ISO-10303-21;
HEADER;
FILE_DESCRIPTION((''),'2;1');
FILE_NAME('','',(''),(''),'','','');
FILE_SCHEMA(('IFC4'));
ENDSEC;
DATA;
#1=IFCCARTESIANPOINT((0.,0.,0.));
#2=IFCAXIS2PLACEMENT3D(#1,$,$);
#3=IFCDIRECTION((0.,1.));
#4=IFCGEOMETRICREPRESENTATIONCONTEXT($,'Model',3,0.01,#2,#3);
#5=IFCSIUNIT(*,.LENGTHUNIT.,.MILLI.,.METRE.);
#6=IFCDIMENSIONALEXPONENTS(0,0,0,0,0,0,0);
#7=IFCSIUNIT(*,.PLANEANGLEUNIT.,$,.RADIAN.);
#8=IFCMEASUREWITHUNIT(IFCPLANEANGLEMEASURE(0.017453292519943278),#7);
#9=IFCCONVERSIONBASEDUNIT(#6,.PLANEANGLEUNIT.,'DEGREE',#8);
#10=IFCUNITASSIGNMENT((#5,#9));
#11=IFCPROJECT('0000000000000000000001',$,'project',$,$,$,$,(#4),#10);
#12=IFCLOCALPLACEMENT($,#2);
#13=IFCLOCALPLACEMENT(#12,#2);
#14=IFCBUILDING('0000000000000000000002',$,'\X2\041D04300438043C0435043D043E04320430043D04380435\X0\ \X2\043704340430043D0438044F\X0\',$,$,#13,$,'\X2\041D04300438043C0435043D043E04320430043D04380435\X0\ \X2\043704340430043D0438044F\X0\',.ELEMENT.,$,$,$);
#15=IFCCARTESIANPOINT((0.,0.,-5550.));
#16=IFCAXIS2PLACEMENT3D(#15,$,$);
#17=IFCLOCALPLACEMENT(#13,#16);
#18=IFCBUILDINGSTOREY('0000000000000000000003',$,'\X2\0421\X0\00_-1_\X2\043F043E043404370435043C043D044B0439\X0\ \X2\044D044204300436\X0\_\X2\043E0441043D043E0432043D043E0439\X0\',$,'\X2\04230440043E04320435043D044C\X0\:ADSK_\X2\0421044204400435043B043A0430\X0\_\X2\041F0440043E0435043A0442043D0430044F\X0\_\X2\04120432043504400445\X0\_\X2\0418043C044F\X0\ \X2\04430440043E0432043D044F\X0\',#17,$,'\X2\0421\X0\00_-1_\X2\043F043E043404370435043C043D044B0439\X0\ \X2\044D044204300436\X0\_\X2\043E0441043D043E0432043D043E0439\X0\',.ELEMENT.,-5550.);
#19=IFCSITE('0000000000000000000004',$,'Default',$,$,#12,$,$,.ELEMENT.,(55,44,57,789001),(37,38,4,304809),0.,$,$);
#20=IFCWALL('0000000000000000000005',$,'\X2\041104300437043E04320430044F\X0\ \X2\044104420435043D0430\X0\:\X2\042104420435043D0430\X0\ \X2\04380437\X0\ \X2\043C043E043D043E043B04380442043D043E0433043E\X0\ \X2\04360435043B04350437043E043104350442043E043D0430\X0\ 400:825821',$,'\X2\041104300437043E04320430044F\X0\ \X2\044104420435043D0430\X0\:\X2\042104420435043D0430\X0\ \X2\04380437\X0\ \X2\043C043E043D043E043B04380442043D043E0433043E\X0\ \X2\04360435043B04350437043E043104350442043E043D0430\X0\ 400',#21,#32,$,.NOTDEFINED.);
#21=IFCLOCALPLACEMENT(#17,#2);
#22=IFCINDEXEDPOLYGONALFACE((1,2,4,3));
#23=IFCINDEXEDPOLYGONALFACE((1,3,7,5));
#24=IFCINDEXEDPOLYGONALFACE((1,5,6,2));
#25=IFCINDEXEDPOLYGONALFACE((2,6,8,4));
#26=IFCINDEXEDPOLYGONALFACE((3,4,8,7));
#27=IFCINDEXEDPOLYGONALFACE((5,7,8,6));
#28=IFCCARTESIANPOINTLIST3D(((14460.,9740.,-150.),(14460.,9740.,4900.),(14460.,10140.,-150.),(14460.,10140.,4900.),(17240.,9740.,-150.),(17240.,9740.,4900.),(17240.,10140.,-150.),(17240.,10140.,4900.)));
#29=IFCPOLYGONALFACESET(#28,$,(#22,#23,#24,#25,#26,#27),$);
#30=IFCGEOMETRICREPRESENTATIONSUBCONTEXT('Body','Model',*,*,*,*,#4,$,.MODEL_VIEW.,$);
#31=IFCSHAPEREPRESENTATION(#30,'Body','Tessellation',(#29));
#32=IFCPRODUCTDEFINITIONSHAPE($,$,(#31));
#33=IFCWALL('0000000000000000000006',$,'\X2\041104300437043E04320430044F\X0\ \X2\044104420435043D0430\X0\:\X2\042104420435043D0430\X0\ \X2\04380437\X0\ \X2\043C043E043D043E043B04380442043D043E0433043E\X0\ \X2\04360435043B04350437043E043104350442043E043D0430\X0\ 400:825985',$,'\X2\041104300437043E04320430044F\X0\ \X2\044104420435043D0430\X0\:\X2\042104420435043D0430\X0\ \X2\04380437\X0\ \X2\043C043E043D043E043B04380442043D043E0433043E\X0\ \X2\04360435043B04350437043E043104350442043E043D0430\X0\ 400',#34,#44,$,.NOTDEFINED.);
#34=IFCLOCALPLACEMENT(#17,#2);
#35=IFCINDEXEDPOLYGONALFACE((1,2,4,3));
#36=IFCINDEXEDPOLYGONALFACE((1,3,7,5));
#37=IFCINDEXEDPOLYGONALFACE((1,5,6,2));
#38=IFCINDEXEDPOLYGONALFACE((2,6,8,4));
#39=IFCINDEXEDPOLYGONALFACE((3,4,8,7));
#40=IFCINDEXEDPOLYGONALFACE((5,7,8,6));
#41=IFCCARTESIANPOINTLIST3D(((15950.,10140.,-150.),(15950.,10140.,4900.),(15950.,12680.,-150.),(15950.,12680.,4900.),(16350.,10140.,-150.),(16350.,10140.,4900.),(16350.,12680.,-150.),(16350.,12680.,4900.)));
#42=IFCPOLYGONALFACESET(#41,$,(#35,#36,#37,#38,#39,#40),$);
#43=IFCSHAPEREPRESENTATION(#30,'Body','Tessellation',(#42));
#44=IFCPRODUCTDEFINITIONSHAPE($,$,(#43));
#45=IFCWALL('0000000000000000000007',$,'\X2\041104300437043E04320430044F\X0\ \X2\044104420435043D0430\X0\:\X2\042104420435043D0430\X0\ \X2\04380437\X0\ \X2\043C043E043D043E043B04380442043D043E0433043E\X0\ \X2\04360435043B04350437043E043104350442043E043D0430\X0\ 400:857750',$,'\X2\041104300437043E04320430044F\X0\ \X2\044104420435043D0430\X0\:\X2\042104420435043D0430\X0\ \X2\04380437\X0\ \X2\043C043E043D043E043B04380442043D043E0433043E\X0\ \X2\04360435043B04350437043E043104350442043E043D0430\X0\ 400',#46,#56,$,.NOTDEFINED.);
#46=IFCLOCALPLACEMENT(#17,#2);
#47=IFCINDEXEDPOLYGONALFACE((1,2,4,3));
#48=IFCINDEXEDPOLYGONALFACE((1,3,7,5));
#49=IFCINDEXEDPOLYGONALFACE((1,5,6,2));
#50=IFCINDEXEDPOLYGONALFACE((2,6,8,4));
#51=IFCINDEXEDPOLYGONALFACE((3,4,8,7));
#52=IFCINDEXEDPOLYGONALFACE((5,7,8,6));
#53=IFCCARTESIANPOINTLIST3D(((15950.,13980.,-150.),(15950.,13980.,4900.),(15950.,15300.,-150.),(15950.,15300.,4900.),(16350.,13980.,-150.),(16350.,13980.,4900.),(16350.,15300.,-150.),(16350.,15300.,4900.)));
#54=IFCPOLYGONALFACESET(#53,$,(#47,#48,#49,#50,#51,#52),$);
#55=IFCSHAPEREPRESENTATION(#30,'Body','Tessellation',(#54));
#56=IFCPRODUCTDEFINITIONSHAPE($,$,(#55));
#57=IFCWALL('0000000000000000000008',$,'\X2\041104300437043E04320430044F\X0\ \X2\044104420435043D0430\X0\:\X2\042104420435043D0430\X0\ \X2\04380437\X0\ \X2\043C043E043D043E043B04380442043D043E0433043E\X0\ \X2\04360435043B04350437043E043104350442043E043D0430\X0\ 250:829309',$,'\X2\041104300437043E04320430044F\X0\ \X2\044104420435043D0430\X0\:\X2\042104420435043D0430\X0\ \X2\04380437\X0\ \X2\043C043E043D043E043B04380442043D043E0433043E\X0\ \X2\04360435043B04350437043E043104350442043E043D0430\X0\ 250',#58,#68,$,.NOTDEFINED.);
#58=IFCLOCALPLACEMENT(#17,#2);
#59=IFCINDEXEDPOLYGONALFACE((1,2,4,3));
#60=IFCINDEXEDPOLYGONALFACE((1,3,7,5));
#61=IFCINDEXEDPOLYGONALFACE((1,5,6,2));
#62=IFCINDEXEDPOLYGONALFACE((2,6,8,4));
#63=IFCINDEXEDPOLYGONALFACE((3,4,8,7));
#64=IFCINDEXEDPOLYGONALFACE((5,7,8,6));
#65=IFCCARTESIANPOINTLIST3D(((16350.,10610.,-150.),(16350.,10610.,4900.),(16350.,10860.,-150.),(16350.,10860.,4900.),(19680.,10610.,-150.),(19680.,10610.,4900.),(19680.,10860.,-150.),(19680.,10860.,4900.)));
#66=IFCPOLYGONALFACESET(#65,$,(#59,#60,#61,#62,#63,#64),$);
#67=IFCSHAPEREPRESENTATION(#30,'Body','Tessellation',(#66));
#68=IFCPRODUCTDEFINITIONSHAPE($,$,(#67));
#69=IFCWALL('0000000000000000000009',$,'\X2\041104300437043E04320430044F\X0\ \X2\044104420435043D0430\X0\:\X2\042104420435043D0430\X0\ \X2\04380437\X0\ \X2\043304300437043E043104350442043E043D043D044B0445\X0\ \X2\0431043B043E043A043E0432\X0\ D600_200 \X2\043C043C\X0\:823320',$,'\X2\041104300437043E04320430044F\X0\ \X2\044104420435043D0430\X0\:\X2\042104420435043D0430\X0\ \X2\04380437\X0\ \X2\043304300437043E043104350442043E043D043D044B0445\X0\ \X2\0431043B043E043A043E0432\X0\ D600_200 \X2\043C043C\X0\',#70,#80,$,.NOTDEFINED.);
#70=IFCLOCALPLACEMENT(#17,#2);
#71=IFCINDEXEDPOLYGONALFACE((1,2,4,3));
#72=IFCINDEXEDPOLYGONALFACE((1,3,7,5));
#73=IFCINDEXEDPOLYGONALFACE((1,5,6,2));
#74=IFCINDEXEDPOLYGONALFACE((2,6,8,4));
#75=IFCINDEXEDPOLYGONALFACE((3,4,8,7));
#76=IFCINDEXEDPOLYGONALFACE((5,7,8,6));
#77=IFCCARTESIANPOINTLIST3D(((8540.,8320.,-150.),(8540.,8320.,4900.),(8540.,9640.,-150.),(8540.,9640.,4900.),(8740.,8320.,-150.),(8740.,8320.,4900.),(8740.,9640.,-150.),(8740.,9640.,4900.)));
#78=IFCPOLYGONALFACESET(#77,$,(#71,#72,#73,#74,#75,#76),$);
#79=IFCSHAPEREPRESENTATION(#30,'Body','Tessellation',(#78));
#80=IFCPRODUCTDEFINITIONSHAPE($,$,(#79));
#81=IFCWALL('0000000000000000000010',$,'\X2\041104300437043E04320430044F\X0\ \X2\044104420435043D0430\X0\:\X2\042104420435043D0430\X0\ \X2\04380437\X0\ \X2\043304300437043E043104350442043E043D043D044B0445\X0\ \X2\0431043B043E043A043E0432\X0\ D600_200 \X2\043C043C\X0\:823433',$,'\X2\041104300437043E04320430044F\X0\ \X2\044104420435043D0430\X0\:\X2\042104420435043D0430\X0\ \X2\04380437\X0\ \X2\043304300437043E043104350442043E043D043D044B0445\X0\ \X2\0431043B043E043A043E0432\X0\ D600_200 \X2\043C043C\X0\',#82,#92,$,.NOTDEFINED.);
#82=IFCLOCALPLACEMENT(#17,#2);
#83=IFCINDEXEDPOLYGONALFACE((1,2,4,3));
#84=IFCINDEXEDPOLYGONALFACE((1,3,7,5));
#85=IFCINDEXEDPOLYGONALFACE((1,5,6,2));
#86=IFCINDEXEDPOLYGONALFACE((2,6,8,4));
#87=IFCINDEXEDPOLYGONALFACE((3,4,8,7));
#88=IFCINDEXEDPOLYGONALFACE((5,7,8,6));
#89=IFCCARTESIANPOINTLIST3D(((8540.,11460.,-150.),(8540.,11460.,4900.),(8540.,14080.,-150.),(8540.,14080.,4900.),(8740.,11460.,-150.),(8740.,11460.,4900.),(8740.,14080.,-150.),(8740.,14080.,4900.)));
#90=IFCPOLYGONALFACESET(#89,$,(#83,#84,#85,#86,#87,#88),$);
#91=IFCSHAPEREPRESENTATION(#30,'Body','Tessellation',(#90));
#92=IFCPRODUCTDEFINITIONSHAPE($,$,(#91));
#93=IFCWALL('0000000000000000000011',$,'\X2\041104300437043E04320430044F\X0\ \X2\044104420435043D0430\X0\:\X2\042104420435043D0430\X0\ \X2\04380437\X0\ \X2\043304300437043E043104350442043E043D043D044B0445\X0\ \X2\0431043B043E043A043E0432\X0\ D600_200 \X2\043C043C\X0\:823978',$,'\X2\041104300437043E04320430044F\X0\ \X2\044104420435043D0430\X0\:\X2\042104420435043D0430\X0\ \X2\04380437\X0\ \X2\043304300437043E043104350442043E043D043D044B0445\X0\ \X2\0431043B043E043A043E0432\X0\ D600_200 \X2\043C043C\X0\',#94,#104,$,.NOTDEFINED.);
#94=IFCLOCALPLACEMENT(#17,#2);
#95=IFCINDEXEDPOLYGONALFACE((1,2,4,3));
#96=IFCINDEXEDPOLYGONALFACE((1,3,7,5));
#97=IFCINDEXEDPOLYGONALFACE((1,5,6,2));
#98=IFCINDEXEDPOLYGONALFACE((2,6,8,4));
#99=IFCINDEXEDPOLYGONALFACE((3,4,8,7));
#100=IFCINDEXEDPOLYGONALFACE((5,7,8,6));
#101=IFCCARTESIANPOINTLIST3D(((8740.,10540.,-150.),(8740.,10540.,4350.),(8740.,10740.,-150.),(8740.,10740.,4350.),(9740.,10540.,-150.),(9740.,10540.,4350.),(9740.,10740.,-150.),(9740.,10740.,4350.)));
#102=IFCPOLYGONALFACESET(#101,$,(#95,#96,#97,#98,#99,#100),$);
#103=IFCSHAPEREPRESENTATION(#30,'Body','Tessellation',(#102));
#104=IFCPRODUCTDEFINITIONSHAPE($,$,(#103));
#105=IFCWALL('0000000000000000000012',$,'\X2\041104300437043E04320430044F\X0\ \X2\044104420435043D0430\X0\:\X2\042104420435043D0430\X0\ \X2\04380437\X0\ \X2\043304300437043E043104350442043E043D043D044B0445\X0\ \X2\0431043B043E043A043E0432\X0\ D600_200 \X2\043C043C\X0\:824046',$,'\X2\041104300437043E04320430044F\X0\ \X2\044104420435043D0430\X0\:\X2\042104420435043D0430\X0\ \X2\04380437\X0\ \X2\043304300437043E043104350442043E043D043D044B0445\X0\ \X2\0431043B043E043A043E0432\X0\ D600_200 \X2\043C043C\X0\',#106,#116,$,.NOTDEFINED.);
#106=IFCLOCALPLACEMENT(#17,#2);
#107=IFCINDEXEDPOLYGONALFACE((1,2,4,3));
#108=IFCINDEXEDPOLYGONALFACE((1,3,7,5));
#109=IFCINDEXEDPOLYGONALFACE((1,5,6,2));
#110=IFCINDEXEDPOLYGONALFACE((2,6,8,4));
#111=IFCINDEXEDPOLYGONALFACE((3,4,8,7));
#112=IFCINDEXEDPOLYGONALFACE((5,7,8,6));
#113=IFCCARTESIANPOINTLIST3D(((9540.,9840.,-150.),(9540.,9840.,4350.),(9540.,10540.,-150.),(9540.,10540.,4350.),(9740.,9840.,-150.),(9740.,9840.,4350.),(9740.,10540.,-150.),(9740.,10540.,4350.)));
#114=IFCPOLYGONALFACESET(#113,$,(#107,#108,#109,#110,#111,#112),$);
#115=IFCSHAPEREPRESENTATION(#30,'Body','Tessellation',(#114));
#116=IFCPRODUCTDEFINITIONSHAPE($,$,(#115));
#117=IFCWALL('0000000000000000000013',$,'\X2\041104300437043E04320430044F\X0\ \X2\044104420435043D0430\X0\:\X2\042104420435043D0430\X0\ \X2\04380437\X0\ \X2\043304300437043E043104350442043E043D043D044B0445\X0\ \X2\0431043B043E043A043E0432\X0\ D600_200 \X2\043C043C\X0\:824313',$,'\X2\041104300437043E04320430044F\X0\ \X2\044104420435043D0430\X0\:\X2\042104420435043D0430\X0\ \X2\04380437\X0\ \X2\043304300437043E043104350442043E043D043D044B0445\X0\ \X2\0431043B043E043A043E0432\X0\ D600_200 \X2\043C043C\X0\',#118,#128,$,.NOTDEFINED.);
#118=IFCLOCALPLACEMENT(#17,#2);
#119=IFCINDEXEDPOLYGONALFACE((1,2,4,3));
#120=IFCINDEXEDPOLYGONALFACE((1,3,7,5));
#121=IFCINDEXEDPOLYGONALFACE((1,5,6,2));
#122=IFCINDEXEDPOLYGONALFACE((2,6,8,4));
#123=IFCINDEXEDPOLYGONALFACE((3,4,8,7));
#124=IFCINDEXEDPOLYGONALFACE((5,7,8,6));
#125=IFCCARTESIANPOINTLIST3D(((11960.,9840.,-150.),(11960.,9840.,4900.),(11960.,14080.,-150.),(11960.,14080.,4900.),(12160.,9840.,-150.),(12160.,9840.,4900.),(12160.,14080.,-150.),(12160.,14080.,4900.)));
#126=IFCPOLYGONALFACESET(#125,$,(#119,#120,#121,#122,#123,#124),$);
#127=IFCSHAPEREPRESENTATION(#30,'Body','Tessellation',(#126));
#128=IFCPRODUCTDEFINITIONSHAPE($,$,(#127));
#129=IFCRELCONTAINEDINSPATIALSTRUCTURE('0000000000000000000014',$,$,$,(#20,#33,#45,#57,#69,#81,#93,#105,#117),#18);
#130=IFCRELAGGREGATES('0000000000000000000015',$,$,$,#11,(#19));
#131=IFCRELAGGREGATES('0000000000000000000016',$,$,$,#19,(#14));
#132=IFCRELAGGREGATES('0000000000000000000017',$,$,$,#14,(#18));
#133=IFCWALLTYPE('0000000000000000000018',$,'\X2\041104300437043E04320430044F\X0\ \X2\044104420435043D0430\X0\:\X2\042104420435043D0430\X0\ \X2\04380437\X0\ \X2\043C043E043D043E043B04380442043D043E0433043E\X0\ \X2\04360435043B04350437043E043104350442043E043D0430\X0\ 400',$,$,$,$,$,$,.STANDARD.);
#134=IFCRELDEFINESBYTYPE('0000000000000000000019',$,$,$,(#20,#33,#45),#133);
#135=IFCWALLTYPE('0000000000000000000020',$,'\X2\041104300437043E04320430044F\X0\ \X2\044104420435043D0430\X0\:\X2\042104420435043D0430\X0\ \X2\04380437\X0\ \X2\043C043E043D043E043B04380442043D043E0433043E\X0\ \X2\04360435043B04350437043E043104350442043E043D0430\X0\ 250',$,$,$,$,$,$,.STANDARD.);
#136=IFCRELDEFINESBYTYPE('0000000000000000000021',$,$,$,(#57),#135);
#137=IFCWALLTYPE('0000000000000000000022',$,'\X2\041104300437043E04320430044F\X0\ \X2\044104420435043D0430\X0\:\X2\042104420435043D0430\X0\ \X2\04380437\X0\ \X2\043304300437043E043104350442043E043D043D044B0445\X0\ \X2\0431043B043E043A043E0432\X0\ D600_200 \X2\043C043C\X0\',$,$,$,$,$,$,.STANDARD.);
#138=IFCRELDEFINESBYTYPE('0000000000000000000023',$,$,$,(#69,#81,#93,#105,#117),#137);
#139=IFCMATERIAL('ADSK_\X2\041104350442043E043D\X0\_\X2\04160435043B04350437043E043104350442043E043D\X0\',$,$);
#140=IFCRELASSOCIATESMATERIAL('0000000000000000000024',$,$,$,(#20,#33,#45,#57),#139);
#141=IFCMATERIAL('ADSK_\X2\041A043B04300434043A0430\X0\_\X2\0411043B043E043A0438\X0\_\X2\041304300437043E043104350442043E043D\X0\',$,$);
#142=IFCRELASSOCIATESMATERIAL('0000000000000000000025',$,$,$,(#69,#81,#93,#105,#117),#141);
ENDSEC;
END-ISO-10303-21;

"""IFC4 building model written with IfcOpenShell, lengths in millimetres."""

from ifc_helpers import new_model, entity, si_unit, converted_unit, direction, frame, origin, place, context, subcontext, project, spatial, indexed_curve, outline, extrude, material, type_object, element, save


model = new_model("IFC4")

# Units and contexts
model_context = context("Model", 3, precision=0.01, world=origin(), true_north=direction((0.0, 1.0)))
body_context = subcontext(model_context, "Body", "Model", "MODEL_VIEW")
ifc_project = project(units=[si_unit("LENGTHUNIT", "METRE", prefix="MILLI"), converted_unit("PLANEANGLEUNIT", "DEGREE", entity("IfcPlaneAngleMeasure", 0.017453292519943278), si_unit("PLANEANGLEUNIT", "RADIAN"), dimensions=[0, 0, 0, 0, 0, 0, 0])], contexts=[model_context])

# Site, building, storey
site_placement = place(None, origin())
site = spatial("IfcSite", under=ifc_project, at=site_placement, Name="Default", CompositionType="ELEMENT", RefLatitude=(55, 44, 57, 789001), RefLongitude=(37, 38, 4, 304809), RefElevation=0.0)
building_placement = place(site_placement, origin())
building = spatial("IfcBuilding", under=site, at=building_placement, Name="Наименование здания", LongName="Наименование здания", CompositionType="ELEMENT")
storey_placement = place(building_placement, frame((0.0, 0.0, -5550.0)))
storey = spatial("IfcBuildingStorey", under=building, at=storey_placement, Name="С00_-1_подземный этаж_основной", ObjectType="Уровень:ADSK_Стрелка_Проектная_Вверх_Имя уровня", LongName="С00_-1_подземный этаж_основной", CompositionType="ELEMENT", Elevation=-5550.0)

# Shared definitions
ifc_material_1 = material(Name="ADSK_Бетон_Железобетон")

# Walls
wall_type_1 = type_object("IfcWallType", Name="Базовая стена:Стена из монолитного железобетона 400", PredefinedType="STANDARD")
wall_1_placement = place(storey_placement, frame((14460.0, 9940.0, -150.0)))
element("IfcWall", 1, at=wall_1_placement, inside=storey, type_object=wall_type_1, material=ifc_material_1, Name="Базовая стена:Стена из монолитного железобетона 400:825821", ObjectType="Базовая стена:Стена из монолитного железобетона 400", PredefinedType="NOTDEFINED", context=body_context, shape_type="SweptSolid", body=[
    extrude(outline(indexed_curve([(2780.0, 200.0), (0.0, 200.0), (0.0, -200.0), (2780.0, -200.0), (2780.0, 200.0)], self_intersect=False)), origin(), (0.0, 0.0, 1.0), 5050.0),
])
wall_2_placement = place(storey_placement, frame((16150.0, 10140.0, -150.0), z_axis=(0.0, 0.0, 1.0), x_axis=(0.0, 1.0, 0.0)))
element("IfcWall", 2, at=wall_2_placement, inside=storey, type_object=wall_type_1, material=ifc_material_1, Name="Базовая стена:Стена из монолитного железобетона 400:825985", ObjectType="Базовая стена:Стена из монолитного железобетона 400", PredefinedType="NOTDEFINED", context=body_context, shape_type="SweptSolid", body=[
    extrude(outline(indexed_curve([(2540.0, 200.0), (0.0, 200.0), (0.0, -200.0), (2540.0, -200.0), (2540.0, 200.0)], self_intersect=False)), origin(), (0.0, 0.0, 1.0), 5050.0),
])
wall_3_placement = place(storey_placement, frame((16150.0, 13980.0, -150.0), z_axis=(0.0, 0.0, 1.0), x_axis=(0.0, 1.0, 0.0)))
element("IfcWall", 3, at=wall_3_placement, inside=storey, type_object=wall_type_1, material=ifc_material_1, Name="Базовая стена:Стена из монолитного железобетона 400:857750", ObjectType="Базовая стена:Стена из монолитного железобетона 400", PredefinedType="NOTDEFINED", context=body_context, shape_type="SweptSolid", body=[
    extrude(outline(indexed_curve([(1320.0, 200.0), (0.0, 200.0), (0.0, -200.0), (1320.0, -200.0), (1320.0, 200.0)], self_intersect=False)), origin(), (0.0, 0.0, 1.0), 5050.0),
])
wall_type_2 = type_object("IfcWallType", Name="Базовая стена:Стена из монолитного железобетона 250", PredefinedType="STANDARD")
wall_4_placement = place(storey_placement, frame((16350.0, 10735.0, -150.0)))
element("IfcWall", 4, at=wall_4_placement, inside=storey, type_object=wall_type_2, material=ifc_material_1, Name="Базовая стена:Стена из монолитного железобетона 250:829309", ObjectType="Базовая стена:Стена из монолитного железобетона 250", PredefinedType="NOTDEFINED", context=body_context, shape_type="SweptSolid", body=[
    extrude(outline(indexed_curve([(3330.0, 125.0), (0.0, 125.0), (0.0, -125.0), (3330.0, -125.0), (3330.0, 125.0)], self_intersect=False)), origin(), (0.0, 0.0, 1.0), 5050.0),
])
ifc_material_2 = material(Name="ADSK_Кладка_Блоки_Газобетон")
wall_type_3 = type_object("IfcWallType", Name="Базовая стена:Стена из газобетонных блоков D600_200 мм", PredefinedType="STANDARD")
wall_5_placement = place(storey_placement, frame((8640.0, 8320.0, -150.0), z_axis=(0.0, 0.0, 1.0), x_axis=(0.0, 1.0, 0.0)))
element("IfcWall", 5, at=wall_5_placement, inside=storey, type_object=wall_type_3, material=ifc_material_2, Name="Базовая стена:Стена из газобетонных блоков D600_200 мм:823320", ObjectType="Базовая стена:Стена из газобетонных блоков D600_200 мм", PredefinedType="NOTDEFINED", context=body_context, shape_type="SweptSolid", body=[
    extrude(outline(indexed_curve([(1320.0, 100.0), (0.0, 100.0), (0.0, -100.0), (1320.0, -100.0), (1320.0, 100.0)], self_intersect=False)), origin(), (0.0, 0.0, 1.0), 5050.0),
])
wall_6_placement = place(storey_placement, frame((8640.0, 11460.0, -150.0), z_axis=(0.0, 0.0, 1.0), x_axis=(0.0, 1.0, 0.0)))
element("IfcWall", 6, at=wall_6_placement, inside=storey, type_object=wall_type_3, material=ifc_material_2, Name="Базовая стена:Стена из газобетонных блоков D600_200 мм:823433", ObjectType="Базовая стена:Стена из газобетонных блоков D600_200 мм", PredefinedType="NOTDEFINED", context=body_context, shape_type="SweptSolid", body=[
    extrude(outline(indexed_curve([(2620.0, 100.0), (0.0, 100.0), (0.0, -100.0), (2620.0, -100.0), (2620.0, 100.0)], self_intersect=False)), origin(), (0.0, 0.0, 1.0), 5050.0),
])
wall_7_placement = place(storey_placement, frame((8740.0, 10640.0, -150.0)))
element("IfcWall", 7, at=wall_7_placement, inside=storey, type_object=wall_type_3, material=ifc_material_2, Name="Базовая стена:Стена из газобетонных блоков D600_200 мм:823978", ObjectType="Базовая стена:Стена из газобетонных блоков D600_200 мм", PredefinedType="NOTDEFINED", context=body_context, shape_type="SweptSolid", body=[
    extrude(outline(indexed_curve([(1000.0, 100.0), (0.0, 100.0), (0.0, -100.0), (1000.0, -100.0), (1000.0, 100.0)], self_intersect=False)), origin(), (0.0, 0.0, 1.0), 4500.0),
])
wall_8_placement = place(storey_placement, frame((9640.0, 10540.0, -150.0), z_axis=(0.0, 0.0, 1.0), x_axis=(0.0, -1.0, 0.0)))
element("IfcWall", 8, at=wall_8_placement, inside=storey, type_object=wall_type_3, material=ifc_material_2, Name="Базовая стена:Стена из газобетонных блоков D600_200 мм:824046", ObjectType="Базовая стена:Стена из газобетонных блоков D600_200 мм", PredefinedType="NOTDEFINED", context=body_context, shape_type="SweptSolid", body=[
    extrude(outline(indexed_curve([(700.0, 100.0), (0.0, 100.0), (0.0, -100.0), (700.0, -100.0), (700.0, 100.0)], self_intersect=False)), origin(), (0.0, 0.0, 1.0), 4500.0),
])
wall_9_placement = place(storey_placement, frame((12060.0, 9840.0, -150.0), z_axis=(0.0, 0.0, 1.0), x_axis=(0.0, 1.0, 0.0)))
element("IfcWall", 9, at=wall_9_placement, inside=storey, type_object=wall_type_3, material=ifc_material_2, Name="Базовая стена:Стена из газобетонных блоков D600_200 мм:824313", ObjectType="Базовая стена:Стена из газобетонных блоков D600_200 мм", PredefinedType="NOTDEFINED", context=body_context, shape_type="SweptSolid", body=[
    extrude(outline(indexed_curve([(4240.0, 100.0), (0.0, 100.0), (0.0, -100.0), (4240.0, -100.0), (4240.0, 100.0)], self_intersect=False)), origin(), (0.0, 0.0, 1.0), 5050.0),
])

save(model, "model.ifc")
